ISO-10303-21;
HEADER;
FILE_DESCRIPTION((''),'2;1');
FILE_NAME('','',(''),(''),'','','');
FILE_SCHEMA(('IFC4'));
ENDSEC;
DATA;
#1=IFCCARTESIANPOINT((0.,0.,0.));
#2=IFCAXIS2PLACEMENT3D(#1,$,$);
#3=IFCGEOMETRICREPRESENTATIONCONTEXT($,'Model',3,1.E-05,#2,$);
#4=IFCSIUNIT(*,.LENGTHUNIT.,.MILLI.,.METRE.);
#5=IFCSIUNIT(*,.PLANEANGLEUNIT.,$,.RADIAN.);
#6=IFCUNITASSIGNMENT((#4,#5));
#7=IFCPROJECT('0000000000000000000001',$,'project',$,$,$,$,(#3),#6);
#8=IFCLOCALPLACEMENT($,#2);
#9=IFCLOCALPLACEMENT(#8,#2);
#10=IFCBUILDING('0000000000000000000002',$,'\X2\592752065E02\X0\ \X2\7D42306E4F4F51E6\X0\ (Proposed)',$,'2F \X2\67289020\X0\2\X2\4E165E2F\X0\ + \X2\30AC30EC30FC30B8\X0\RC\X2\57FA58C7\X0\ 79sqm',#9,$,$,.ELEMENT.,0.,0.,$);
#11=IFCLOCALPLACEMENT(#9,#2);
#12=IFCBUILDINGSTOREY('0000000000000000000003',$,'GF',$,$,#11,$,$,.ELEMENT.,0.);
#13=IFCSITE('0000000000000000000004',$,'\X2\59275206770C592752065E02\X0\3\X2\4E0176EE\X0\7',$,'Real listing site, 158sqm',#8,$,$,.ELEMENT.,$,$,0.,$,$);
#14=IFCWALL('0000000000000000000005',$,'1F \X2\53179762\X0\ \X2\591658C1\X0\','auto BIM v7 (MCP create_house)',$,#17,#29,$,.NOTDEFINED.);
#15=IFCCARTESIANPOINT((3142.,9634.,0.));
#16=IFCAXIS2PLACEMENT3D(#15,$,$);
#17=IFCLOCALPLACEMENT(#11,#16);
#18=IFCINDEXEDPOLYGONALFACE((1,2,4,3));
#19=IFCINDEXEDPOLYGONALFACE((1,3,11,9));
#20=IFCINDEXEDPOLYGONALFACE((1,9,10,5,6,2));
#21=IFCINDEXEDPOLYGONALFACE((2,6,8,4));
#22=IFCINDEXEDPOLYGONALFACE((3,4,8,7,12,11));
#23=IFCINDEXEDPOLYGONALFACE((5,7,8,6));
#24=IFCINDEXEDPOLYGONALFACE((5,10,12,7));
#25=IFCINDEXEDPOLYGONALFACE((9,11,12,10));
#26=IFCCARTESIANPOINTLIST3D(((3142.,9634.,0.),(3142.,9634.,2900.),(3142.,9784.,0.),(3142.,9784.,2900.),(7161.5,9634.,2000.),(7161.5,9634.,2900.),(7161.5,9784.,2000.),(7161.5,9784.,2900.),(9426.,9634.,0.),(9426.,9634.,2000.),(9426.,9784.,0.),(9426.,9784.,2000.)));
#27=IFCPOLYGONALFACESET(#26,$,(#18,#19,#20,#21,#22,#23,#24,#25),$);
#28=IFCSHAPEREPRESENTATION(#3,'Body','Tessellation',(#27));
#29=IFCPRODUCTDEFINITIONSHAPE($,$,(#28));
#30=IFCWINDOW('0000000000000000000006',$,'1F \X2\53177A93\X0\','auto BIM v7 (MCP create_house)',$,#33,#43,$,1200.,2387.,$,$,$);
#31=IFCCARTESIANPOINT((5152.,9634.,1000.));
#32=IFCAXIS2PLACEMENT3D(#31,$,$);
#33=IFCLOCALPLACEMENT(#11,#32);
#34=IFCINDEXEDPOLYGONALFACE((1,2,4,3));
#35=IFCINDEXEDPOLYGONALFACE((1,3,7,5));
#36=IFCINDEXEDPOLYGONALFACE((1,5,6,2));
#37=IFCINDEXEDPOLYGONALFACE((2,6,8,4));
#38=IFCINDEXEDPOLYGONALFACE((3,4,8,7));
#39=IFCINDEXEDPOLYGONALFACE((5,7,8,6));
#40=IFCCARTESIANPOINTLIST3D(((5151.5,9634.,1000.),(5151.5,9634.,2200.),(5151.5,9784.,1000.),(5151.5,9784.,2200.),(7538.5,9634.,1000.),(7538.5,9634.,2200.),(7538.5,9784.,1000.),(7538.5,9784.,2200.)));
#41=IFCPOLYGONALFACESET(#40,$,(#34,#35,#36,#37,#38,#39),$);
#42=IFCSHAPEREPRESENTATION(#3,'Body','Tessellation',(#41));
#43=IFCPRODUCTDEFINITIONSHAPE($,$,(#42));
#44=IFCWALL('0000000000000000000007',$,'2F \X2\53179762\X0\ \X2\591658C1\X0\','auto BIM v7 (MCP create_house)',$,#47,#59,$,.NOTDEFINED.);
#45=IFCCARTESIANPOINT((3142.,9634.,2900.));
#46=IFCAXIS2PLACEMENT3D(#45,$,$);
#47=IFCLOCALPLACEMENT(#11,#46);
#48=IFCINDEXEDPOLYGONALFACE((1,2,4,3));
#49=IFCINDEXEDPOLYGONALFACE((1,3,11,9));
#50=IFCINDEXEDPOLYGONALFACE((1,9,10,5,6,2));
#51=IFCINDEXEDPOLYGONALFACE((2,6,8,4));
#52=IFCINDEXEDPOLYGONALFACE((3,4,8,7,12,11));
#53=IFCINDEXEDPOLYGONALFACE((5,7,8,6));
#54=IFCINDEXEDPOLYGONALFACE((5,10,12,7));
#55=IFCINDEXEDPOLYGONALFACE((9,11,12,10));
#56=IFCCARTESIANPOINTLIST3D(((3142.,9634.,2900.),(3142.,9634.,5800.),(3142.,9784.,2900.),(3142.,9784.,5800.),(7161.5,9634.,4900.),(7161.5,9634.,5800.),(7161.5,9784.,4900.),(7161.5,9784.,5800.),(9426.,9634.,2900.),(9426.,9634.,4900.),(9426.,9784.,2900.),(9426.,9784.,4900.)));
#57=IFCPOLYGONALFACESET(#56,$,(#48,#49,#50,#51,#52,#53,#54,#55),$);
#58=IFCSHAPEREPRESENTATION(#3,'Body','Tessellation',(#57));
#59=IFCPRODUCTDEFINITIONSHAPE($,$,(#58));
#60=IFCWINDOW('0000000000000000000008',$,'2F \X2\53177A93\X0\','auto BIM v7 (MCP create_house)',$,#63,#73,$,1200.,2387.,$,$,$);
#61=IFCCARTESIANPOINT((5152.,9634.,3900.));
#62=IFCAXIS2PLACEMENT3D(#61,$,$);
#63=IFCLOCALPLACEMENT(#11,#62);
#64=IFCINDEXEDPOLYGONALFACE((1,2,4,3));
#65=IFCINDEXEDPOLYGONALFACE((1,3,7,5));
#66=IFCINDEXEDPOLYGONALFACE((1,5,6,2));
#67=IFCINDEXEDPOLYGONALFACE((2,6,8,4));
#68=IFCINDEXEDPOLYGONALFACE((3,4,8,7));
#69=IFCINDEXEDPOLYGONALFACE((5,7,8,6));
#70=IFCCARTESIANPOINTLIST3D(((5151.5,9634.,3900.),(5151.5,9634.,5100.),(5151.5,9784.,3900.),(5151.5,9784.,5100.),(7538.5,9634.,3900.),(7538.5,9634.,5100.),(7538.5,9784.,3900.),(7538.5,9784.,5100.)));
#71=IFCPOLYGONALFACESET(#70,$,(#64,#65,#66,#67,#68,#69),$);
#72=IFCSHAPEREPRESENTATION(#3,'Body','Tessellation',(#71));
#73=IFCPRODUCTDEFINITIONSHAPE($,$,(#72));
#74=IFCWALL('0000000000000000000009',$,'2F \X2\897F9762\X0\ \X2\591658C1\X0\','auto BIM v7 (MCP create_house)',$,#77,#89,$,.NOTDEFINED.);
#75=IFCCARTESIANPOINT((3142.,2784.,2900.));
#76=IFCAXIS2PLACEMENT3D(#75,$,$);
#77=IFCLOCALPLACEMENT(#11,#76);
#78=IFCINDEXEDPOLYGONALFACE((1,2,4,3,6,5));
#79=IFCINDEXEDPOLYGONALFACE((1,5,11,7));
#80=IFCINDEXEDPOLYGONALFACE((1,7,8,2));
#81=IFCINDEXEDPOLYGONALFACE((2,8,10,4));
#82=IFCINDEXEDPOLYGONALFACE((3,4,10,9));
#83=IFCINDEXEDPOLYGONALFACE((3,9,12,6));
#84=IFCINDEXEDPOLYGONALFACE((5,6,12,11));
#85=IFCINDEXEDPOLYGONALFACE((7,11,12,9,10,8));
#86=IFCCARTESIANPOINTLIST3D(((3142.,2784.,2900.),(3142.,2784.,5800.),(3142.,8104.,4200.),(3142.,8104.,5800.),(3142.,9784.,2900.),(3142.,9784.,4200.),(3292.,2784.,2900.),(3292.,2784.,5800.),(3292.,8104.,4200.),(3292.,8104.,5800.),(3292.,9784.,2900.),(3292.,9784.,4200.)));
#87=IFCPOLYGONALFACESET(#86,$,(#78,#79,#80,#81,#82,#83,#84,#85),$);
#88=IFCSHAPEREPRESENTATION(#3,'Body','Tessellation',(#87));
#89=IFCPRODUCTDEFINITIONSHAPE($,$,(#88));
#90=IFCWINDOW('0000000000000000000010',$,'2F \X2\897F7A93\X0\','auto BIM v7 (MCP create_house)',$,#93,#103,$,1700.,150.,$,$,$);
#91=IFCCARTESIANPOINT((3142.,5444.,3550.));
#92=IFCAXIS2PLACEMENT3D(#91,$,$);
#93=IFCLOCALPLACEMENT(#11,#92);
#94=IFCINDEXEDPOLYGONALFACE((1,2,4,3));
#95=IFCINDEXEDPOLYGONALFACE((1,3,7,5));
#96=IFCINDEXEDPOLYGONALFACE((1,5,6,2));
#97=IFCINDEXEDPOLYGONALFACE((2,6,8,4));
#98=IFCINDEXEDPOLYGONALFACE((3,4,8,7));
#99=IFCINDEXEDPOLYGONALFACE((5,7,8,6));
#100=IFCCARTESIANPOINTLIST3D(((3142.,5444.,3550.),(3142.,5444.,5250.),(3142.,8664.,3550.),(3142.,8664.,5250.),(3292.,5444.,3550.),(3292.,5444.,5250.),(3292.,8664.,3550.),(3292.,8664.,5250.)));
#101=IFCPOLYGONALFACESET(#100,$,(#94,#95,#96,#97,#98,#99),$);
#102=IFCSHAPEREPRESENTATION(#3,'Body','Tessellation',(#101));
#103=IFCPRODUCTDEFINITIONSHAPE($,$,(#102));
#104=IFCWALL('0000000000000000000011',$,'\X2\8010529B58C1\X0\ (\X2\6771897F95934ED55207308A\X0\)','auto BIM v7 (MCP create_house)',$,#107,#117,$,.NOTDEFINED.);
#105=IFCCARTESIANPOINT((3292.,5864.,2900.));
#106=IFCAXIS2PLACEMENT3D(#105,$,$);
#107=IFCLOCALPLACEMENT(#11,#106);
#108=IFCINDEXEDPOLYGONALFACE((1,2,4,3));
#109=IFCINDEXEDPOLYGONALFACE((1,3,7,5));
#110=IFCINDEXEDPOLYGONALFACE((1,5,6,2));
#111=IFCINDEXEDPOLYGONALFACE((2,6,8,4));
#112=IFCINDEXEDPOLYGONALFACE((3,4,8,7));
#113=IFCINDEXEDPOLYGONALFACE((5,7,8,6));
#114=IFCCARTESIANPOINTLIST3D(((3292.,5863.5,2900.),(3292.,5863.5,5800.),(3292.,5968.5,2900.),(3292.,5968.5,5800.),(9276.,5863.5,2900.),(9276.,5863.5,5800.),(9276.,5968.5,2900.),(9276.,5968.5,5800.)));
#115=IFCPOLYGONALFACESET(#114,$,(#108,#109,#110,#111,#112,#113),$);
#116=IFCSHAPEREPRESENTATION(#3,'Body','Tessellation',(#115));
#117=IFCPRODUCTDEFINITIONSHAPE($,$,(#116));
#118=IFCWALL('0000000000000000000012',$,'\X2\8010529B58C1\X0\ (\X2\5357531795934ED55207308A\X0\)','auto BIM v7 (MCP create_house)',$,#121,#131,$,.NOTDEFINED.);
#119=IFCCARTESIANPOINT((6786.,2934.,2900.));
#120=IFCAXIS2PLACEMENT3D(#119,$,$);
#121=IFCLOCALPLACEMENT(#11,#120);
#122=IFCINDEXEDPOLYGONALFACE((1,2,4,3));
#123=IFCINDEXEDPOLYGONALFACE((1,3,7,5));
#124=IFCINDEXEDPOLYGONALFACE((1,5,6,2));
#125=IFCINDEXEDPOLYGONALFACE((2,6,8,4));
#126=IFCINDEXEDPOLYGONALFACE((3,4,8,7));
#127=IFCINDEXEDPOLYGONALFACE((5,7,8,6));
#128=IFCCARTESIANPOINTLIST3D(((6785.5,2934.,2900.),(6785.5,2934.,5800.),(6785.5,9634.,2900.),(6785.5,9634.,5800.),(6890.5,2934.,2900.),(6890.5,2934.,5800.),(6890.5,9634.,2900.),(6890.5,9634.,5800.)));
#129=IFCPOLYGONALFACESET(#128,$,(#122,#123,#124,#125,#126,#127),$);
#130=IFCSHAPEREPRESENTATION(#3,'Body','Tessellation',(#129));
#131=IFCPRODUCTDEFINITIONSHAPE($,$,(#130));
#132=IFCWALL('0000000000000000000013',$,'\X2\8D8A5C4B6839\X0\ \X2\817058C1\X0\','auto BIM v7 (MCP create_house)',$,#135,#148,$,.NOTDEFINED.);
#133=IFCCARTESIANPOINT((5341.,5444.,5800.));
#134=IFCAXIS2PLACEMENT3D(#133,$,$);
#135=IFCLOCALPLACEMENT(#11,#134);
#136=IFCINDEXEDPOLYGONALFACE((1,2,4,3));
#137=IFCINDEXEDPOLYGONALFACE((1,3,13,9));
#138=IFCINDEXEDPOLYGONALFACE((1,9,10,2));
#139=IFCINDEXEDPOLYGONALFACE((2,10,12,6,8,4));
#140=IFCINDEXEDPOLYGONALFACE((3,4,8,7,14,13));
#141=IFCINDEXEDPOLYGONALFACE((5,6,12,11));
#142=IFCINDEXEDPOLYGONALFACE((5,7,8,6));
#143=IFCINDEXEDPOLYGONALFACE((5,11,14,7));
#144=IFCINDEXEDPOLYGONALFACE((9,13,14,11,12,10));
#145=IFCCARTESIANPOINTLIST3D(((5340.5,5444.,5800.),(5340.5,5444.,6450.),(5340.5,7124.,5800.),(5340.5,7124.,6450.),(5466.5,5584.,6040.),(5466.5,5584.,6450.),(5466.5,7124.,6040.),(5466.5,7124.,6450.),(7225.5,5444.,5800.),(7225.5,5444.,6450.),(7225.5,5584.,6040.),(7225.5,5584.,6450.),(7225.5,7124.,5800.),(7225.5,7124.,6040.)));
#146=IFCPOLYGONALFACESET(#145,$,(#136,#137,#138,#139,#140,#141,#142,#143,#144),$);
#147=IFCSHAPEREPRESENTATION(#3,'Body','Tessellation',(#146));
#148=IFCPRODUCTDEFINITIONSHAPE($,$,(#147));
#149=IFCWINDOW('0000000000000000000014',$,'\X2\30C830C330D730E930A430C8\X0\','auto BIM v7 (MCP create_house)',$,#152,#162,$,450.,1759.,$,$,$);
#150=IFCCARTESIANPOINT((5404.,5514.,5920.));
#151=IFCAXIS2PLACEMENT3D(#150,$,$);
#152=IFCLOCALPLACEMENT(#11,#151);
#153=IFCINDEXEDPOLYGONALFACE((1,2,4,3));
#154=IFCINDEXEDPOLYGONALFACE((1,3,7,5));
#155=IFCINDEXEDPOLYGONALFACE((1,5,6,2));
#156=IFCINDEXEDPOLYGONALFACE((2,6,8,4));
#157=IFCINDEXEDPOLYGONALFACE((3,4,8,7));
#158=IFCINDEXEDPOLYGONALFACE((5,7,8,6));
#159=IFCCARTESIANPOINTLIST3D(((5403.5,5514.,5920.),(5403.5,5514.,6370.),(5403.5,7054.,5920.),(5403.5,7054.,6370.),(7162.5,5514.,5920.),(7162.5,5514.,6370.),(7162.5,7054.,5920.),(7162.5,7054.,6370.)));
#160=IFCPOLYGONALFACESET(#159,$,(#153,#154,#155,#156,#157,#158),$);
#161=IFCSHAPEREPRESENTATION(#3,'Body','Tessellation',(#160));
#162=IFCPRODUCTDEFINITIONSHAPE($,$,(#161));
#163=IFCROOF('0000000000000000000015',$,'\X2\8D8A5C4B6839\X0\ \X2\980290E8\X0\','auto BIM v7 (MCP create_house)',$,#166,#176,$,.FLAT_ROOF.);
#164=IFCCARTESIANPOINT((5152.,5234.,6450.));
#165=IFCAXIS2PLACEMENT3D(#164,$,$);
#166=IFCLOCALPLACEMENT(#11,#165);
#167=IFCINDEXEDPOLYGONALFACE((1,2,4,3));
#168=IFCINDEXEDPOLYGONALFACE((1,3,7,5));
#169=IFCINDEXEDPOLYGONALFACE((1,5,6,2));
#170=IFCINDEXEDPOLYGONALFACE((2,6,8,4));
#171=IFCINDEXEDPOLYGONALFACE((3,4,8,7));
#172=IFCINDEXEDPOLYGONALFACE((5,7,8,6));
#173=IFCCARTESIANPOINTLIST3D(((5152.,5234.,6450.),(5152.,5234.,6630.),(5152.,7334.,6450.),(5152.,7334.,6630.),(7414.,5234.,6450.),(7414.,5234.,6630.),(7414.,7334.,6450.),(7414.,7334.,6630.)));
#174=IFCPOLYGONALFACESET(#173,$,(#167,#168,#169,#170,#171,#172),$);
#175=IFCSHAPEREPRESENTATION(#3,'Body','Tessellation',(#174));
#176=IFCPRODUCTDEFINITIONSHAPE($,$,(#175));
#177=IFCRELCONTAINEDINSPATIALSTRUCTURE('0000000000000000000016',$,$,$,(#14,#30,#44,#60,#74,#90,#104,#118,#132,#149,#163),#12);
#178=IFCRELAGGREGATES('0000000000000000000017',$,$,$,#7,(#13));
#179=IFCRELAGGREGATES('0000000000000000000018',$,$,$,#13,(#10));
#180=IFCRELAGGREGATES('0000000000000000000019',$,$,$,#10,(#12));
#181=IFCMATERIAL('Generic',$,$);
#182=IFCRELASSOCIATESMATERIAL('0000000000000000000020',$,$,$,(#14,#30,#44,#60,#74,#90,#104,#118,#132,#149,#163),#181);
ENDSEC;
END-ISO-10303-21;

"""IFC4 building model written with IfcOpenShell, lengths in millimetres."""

from ifc_helpers import new_model, si_unit, frame, frame_2d, origin, place, context, project, spatial, rectangle, extrude, material, element, fill, save


model = new_model("IFC4")

# Units and contexts
model_context = context("Model", 3, precision=1e-05, world=origin())
ifc_project = project(units=[si_unit("LENGTHUNIT", "METRE", prefix="MILLI"), si_unit("PLANEANGLEUNIT", "RADIAN")], contexts=[model_context])

# Site, building, storey
site_placement = place(None, origin())
site = spatial("IfcSite", under=ifc_project, at=site_placement, Name="大分県大分市3丁目7", ObjectType="Real listing site, 158sqm", CompositionType="ELEMENT", RefElevation=0.0)
building_placement = place(site_placement, origin())
building = spatial("IfcBuilding", under=site, at=building_placement, Name="大分市 終の住処 (Proposed)", ObjectType="2F 木造2世帯 + ガレージRC基壇 79sqm", CompositionType="ELEMENT", ElevationOfRefHeight=0.0, ElevationOfTerrain=0.0)
storey_placement = place(building_placement, origin())
storey = spatial("IfcBuildingStorey", under=building, at=storey_placement, Name="GF", CompositionType="ELEMENT", Elevation=0.0)

# Wall, opening, window
ifc_material = material(Name="Generic")
wall_1_placement = place(storey_placement, frame((3142.0, 9634.0, 0.0)))
wall_1 = element("IfcWall", 1, at=wall_1_placement, inside=storey, material=ifc_material, Name="1F 北面 外壁", Description="auto BIM v7 (MCP create_house)", PredefinedType="NOTDEFINED", context=model_context, shape_type="SweptSolid", body=[
    extrude(rectangle(XDim=6284.0, YDim=150.0, at=frame_2d((3142.0, 75.0))), frame((3142.0, 9634.0, 0.0)), (0.0, 0.0, 1.0), 2900.0),
])
opening_1_placement = place(storey_placement, frame((5152.0, 9634.0, 1000.0)))
opening_1 = element("IfcOpeningElement", 2, at=opening_1_placement, cuts=wall_1, PredefinedType="NOTDEFINED", context=model_context, shape_type="SweptSolid", body=[
    extrude(rectangle(XDim=2387.0, YDim=150.0, at=frame_2d((1193.0, 75.0))), frame((5152.0, 9634.0, 1000.0)), (0.0, 0.0, 1.0), 1200.0),
])
window_1_placement = place(storey_placement, frame((5152.0, 9634.0, 1000.0)))
window_1 = element("IfcWindow", 3, at=window_1_placement, inside=storey, material=ifc_material, Name="1F 北窓", Description="auto BIM v7 (MCP create_house)", OverallHeight=1200.0, OverallWidth=2387.0, context=model_context, shape_type="SweptSolid", body=[
    extrude(rectangle(XDim=2387.0, YDim=150.0, at=frame_2d((1193.0, 75.0))), frame((5152.0, 9634.0, 1000.0)), (0.0, 0.0, 1.0), 1200.0),
])
fill(opening_1, window_1)

# Walls, openings, windows
wall_2_placement = place(storey_placement, frame((3142.0, 9634.0, 2900.0)))
wall_2 = element("IfcWall", 4, at=wall_2_placement, inside=storey, material=ifc_material, Name="2F 北面 外壁", Description="auto BIM v7 (MCP create_house)", PredefinedType="NOTDEFINED", context=model_context, shape_type="SweptSolid", body=[
    extrude(rectangle(XDim=6284.0, YDim=150.0, at=frame_2d((3142.0, 75.0))), frame((3142.0, 9634.0, 2900.0)), (0.0, 0.0, 1.0), 2900.0),
])
opening_2_placement = place(storey_placement, frame((5152.0, 9634.0, 3900.0)))
opening_2 = element("IfcOpeningElement", 5, at=opening_2_placement, cuts=wall_2, PredefinedType="NOTDEFINED", context=model_context, shape_type="SweptSolid", body=[
    extrude(rectangle(XDim=2387.0, YDim=150.0, at=frame_2d((1193.0, 75.0))), frame((5152.0, 9634.0, 3900.0)), (0.0, 0.0, 1.0), 1200.0),
])
window_2_placement = place(storey_placement, frame((5152.0, 9634.0, 3900.0)))
window_2 = element("IfcWindow", 6, at=window_2_placement, inside=storey, material=ifc_material, Name="2F 北窓", Description="auto BIM v7 (MCP create_house)", OverallHeight=1200.0, OverallWidth=2387.0, context=model_context, shape_type="SweptSolid", body=[
    extrude(rectangle(XDim=2387.0, YDim=150.0, at=frame_2d((1193.0, 75.0))), frame((5152.0, 9634.0, 3900.0)), (0.0, 0.0, 1.0), 1200.0),
])
fill(opening_2, window_2)
wall_3_placement = place(storey_placement, frame((3142.0, 2784.0, 2900.0)))
wall_3 = element("IfcWall", 7, at=wall_3_placement, inside=storey, material=ifc_material, Name="2F 西面 外壁", Description="auto BIM v7 (MCP create_house)", PredefinedType="NOTDEFINED", context=model_context, shape_type="SweptSolid", body=[
    extrude(rectangle(XDim=150.0, YDim=7000.0, at=frame_2d((75.0, 3500.0))), frame((3142.0, 2784.0, 2900.0)), (0.0, 0.0, 1.0), 2900.0),
])
opening_3_placement = place(storey_placement, frame((3142.0, 5444.0, 3550.0)))
opening_3 = element("IfcOpeningElement", 8, at=opening_3_placement, cuts=wall_3, PredefinedType="NOTDEFINED", context=model_context, shape_type="SweptSolid", body=[
    extrude(rectangle(XDim=150.0, YDim=3220.0, at=frame_2d((75.0, 1610.0))), frame((3142.0, 5444.0, 3550.0)), (0.0, 0.0, 1.0), 1700.0),
])
window_3_placement = place(storey_placement, frame((3142.0, 5444.0, 3550.0)))
window_3 = element("IfcWindow", 9, at=window_3_placement, inside=storey, material=ifc_material, Name="2F 西窓", Description="auto BIM v7 (MCP create_house)", OverallHeight=1700.0, OverallWidth=150.0, context=model_context, shape_type="SweptSolid", body=[
    extrude(rectangle(XDim=150.0, YDim=3220.0, at=frame_2d((75.0, 1610.0))), frame((3142.0, 5444.0, 3550.0)), (0.0, 0.0, 1.0), 1700.0),
])
fill(opening_3, window_3)

# Walls
wall_4_placement = place(storey_placement, frame((3292.0, 5864.0, 2900.0)))
element("IfcWall", 10, at=wall_4_placement, inside=storey, material=ifc_material, Name="耐力壁 (東西間仕切り)", Description="auto BIM v7 (MCP create_house)", PredefinedType="NOTDEFINED", context=model_context, shape_type="SweptSolid", body=[
    extrude(rectangle(XDim=5984.0, YDim=105.0, at=frame_2d((2992.0, 52.0))), frame((3292.0, 5864.0, 2900.0)), (0.0, 0.0, 1.0), 2900.0),
])
wall_5_placement = place(storey_placement, frame((6786.0, 2934.0, 2900.0)))
element("IfcWall", 11, at=wall_5_placement, inside=storey, material=ifc_material, Name="耐力壁 (南北間仕切り)", Description="auto BIM v7 (MCP create_house)", PredefinedType="NOTDEFINED", context=model_context, shape_type="SweptSolid", body=[
    extrude(rectangle(XDim=105.0, YDim=6700.0, at=frame_2d((52.0, 3350.0))), frame((6786.0, 2934.0, 2900.0)), (0.0, 0.0, 1.0), 2900.0),
])

# Wall, opening, window
wall_6_placement = place(storey_placement, frame((5341.0, 5444.0, 5800.0)))
wall_6 = element("IfcWall", 12, at=wall_6_placement, inside=storey, material=ifc_material, Name="越屋根 腰壁", Description="auto BIM v7 (MCP create_house)", PredefinedType="NOTDEFINED", context=model_context, shape_type="SweptSolid", body=[
    extrude(rectangle(XDim=1885.0, YDim=1680.0, at=frame_2d((942.0, 840.0))), frame((5341.0, 5444.0, 5800.0)), (0.0, 0.0, 1.0), 650.0),
])
opening_4_placement = place(storey_placement, frame((5404.0, 5514.0, 5920.0)))
opening_4 = element("IfcOpeningElement", 13, at=opening_4_placement, cuts=wall_6, PredefinedType="NOTDEFINED", context=model_context, shape_type="SweptSolid", body=[
    extrude(rectangle(XDim=1759.0, YDim=1540.0, at=frame_2d((879.0, 770.0))), frame((5404.0, 5514.0, 5920.0)), (0.0, 0.0, 1.0), 450.0),
])
window_4_placement = place(storey_placement, frame((5404.0, 5514.0, 5920.0)))
window_4 = element("IfcWindow", 14, at=window_4_placement, inside=storey, material=ifc_material, Name="トップライト", Description="auto BIM v7 (MCP create_house)", OverallHeight=450.0, OverallWidth=1759.0, context=model_context, shape_type="SweptSolid", body=[
    extrude(rectangle(XDim=1759.0, YDim=1540.0, at=frame_2d((879.0, 770.0))), frame((5404.0, 5514.0, 5920.0)), (0.0, 0.0, 1.0), 450.0),
])
fill(opening_4, window_4)

# Roof
roof_placement = place(storey_placement, frame((5152.0, 5234.0, 6450.0)))
element("IfcRoof", 15, at=roof_placement, inside=storey, material=ifc_material, Name="越屋根 頂部", Description="auto BIM v7 (MCP create_house)", PredefinedType="FLAT_ROOF", context=model_context, shape_type="SweptSolid", body=[
    extrude(rectangle(XDim=2262.0, YDim=2100.0, at=frame_2d((1131.0, 1050.0))), frame((5152.0, 5234.0, 6450.0)), (0.0, 0.0, 1.0), 180.0),
])

save(model, "model.ifc")
